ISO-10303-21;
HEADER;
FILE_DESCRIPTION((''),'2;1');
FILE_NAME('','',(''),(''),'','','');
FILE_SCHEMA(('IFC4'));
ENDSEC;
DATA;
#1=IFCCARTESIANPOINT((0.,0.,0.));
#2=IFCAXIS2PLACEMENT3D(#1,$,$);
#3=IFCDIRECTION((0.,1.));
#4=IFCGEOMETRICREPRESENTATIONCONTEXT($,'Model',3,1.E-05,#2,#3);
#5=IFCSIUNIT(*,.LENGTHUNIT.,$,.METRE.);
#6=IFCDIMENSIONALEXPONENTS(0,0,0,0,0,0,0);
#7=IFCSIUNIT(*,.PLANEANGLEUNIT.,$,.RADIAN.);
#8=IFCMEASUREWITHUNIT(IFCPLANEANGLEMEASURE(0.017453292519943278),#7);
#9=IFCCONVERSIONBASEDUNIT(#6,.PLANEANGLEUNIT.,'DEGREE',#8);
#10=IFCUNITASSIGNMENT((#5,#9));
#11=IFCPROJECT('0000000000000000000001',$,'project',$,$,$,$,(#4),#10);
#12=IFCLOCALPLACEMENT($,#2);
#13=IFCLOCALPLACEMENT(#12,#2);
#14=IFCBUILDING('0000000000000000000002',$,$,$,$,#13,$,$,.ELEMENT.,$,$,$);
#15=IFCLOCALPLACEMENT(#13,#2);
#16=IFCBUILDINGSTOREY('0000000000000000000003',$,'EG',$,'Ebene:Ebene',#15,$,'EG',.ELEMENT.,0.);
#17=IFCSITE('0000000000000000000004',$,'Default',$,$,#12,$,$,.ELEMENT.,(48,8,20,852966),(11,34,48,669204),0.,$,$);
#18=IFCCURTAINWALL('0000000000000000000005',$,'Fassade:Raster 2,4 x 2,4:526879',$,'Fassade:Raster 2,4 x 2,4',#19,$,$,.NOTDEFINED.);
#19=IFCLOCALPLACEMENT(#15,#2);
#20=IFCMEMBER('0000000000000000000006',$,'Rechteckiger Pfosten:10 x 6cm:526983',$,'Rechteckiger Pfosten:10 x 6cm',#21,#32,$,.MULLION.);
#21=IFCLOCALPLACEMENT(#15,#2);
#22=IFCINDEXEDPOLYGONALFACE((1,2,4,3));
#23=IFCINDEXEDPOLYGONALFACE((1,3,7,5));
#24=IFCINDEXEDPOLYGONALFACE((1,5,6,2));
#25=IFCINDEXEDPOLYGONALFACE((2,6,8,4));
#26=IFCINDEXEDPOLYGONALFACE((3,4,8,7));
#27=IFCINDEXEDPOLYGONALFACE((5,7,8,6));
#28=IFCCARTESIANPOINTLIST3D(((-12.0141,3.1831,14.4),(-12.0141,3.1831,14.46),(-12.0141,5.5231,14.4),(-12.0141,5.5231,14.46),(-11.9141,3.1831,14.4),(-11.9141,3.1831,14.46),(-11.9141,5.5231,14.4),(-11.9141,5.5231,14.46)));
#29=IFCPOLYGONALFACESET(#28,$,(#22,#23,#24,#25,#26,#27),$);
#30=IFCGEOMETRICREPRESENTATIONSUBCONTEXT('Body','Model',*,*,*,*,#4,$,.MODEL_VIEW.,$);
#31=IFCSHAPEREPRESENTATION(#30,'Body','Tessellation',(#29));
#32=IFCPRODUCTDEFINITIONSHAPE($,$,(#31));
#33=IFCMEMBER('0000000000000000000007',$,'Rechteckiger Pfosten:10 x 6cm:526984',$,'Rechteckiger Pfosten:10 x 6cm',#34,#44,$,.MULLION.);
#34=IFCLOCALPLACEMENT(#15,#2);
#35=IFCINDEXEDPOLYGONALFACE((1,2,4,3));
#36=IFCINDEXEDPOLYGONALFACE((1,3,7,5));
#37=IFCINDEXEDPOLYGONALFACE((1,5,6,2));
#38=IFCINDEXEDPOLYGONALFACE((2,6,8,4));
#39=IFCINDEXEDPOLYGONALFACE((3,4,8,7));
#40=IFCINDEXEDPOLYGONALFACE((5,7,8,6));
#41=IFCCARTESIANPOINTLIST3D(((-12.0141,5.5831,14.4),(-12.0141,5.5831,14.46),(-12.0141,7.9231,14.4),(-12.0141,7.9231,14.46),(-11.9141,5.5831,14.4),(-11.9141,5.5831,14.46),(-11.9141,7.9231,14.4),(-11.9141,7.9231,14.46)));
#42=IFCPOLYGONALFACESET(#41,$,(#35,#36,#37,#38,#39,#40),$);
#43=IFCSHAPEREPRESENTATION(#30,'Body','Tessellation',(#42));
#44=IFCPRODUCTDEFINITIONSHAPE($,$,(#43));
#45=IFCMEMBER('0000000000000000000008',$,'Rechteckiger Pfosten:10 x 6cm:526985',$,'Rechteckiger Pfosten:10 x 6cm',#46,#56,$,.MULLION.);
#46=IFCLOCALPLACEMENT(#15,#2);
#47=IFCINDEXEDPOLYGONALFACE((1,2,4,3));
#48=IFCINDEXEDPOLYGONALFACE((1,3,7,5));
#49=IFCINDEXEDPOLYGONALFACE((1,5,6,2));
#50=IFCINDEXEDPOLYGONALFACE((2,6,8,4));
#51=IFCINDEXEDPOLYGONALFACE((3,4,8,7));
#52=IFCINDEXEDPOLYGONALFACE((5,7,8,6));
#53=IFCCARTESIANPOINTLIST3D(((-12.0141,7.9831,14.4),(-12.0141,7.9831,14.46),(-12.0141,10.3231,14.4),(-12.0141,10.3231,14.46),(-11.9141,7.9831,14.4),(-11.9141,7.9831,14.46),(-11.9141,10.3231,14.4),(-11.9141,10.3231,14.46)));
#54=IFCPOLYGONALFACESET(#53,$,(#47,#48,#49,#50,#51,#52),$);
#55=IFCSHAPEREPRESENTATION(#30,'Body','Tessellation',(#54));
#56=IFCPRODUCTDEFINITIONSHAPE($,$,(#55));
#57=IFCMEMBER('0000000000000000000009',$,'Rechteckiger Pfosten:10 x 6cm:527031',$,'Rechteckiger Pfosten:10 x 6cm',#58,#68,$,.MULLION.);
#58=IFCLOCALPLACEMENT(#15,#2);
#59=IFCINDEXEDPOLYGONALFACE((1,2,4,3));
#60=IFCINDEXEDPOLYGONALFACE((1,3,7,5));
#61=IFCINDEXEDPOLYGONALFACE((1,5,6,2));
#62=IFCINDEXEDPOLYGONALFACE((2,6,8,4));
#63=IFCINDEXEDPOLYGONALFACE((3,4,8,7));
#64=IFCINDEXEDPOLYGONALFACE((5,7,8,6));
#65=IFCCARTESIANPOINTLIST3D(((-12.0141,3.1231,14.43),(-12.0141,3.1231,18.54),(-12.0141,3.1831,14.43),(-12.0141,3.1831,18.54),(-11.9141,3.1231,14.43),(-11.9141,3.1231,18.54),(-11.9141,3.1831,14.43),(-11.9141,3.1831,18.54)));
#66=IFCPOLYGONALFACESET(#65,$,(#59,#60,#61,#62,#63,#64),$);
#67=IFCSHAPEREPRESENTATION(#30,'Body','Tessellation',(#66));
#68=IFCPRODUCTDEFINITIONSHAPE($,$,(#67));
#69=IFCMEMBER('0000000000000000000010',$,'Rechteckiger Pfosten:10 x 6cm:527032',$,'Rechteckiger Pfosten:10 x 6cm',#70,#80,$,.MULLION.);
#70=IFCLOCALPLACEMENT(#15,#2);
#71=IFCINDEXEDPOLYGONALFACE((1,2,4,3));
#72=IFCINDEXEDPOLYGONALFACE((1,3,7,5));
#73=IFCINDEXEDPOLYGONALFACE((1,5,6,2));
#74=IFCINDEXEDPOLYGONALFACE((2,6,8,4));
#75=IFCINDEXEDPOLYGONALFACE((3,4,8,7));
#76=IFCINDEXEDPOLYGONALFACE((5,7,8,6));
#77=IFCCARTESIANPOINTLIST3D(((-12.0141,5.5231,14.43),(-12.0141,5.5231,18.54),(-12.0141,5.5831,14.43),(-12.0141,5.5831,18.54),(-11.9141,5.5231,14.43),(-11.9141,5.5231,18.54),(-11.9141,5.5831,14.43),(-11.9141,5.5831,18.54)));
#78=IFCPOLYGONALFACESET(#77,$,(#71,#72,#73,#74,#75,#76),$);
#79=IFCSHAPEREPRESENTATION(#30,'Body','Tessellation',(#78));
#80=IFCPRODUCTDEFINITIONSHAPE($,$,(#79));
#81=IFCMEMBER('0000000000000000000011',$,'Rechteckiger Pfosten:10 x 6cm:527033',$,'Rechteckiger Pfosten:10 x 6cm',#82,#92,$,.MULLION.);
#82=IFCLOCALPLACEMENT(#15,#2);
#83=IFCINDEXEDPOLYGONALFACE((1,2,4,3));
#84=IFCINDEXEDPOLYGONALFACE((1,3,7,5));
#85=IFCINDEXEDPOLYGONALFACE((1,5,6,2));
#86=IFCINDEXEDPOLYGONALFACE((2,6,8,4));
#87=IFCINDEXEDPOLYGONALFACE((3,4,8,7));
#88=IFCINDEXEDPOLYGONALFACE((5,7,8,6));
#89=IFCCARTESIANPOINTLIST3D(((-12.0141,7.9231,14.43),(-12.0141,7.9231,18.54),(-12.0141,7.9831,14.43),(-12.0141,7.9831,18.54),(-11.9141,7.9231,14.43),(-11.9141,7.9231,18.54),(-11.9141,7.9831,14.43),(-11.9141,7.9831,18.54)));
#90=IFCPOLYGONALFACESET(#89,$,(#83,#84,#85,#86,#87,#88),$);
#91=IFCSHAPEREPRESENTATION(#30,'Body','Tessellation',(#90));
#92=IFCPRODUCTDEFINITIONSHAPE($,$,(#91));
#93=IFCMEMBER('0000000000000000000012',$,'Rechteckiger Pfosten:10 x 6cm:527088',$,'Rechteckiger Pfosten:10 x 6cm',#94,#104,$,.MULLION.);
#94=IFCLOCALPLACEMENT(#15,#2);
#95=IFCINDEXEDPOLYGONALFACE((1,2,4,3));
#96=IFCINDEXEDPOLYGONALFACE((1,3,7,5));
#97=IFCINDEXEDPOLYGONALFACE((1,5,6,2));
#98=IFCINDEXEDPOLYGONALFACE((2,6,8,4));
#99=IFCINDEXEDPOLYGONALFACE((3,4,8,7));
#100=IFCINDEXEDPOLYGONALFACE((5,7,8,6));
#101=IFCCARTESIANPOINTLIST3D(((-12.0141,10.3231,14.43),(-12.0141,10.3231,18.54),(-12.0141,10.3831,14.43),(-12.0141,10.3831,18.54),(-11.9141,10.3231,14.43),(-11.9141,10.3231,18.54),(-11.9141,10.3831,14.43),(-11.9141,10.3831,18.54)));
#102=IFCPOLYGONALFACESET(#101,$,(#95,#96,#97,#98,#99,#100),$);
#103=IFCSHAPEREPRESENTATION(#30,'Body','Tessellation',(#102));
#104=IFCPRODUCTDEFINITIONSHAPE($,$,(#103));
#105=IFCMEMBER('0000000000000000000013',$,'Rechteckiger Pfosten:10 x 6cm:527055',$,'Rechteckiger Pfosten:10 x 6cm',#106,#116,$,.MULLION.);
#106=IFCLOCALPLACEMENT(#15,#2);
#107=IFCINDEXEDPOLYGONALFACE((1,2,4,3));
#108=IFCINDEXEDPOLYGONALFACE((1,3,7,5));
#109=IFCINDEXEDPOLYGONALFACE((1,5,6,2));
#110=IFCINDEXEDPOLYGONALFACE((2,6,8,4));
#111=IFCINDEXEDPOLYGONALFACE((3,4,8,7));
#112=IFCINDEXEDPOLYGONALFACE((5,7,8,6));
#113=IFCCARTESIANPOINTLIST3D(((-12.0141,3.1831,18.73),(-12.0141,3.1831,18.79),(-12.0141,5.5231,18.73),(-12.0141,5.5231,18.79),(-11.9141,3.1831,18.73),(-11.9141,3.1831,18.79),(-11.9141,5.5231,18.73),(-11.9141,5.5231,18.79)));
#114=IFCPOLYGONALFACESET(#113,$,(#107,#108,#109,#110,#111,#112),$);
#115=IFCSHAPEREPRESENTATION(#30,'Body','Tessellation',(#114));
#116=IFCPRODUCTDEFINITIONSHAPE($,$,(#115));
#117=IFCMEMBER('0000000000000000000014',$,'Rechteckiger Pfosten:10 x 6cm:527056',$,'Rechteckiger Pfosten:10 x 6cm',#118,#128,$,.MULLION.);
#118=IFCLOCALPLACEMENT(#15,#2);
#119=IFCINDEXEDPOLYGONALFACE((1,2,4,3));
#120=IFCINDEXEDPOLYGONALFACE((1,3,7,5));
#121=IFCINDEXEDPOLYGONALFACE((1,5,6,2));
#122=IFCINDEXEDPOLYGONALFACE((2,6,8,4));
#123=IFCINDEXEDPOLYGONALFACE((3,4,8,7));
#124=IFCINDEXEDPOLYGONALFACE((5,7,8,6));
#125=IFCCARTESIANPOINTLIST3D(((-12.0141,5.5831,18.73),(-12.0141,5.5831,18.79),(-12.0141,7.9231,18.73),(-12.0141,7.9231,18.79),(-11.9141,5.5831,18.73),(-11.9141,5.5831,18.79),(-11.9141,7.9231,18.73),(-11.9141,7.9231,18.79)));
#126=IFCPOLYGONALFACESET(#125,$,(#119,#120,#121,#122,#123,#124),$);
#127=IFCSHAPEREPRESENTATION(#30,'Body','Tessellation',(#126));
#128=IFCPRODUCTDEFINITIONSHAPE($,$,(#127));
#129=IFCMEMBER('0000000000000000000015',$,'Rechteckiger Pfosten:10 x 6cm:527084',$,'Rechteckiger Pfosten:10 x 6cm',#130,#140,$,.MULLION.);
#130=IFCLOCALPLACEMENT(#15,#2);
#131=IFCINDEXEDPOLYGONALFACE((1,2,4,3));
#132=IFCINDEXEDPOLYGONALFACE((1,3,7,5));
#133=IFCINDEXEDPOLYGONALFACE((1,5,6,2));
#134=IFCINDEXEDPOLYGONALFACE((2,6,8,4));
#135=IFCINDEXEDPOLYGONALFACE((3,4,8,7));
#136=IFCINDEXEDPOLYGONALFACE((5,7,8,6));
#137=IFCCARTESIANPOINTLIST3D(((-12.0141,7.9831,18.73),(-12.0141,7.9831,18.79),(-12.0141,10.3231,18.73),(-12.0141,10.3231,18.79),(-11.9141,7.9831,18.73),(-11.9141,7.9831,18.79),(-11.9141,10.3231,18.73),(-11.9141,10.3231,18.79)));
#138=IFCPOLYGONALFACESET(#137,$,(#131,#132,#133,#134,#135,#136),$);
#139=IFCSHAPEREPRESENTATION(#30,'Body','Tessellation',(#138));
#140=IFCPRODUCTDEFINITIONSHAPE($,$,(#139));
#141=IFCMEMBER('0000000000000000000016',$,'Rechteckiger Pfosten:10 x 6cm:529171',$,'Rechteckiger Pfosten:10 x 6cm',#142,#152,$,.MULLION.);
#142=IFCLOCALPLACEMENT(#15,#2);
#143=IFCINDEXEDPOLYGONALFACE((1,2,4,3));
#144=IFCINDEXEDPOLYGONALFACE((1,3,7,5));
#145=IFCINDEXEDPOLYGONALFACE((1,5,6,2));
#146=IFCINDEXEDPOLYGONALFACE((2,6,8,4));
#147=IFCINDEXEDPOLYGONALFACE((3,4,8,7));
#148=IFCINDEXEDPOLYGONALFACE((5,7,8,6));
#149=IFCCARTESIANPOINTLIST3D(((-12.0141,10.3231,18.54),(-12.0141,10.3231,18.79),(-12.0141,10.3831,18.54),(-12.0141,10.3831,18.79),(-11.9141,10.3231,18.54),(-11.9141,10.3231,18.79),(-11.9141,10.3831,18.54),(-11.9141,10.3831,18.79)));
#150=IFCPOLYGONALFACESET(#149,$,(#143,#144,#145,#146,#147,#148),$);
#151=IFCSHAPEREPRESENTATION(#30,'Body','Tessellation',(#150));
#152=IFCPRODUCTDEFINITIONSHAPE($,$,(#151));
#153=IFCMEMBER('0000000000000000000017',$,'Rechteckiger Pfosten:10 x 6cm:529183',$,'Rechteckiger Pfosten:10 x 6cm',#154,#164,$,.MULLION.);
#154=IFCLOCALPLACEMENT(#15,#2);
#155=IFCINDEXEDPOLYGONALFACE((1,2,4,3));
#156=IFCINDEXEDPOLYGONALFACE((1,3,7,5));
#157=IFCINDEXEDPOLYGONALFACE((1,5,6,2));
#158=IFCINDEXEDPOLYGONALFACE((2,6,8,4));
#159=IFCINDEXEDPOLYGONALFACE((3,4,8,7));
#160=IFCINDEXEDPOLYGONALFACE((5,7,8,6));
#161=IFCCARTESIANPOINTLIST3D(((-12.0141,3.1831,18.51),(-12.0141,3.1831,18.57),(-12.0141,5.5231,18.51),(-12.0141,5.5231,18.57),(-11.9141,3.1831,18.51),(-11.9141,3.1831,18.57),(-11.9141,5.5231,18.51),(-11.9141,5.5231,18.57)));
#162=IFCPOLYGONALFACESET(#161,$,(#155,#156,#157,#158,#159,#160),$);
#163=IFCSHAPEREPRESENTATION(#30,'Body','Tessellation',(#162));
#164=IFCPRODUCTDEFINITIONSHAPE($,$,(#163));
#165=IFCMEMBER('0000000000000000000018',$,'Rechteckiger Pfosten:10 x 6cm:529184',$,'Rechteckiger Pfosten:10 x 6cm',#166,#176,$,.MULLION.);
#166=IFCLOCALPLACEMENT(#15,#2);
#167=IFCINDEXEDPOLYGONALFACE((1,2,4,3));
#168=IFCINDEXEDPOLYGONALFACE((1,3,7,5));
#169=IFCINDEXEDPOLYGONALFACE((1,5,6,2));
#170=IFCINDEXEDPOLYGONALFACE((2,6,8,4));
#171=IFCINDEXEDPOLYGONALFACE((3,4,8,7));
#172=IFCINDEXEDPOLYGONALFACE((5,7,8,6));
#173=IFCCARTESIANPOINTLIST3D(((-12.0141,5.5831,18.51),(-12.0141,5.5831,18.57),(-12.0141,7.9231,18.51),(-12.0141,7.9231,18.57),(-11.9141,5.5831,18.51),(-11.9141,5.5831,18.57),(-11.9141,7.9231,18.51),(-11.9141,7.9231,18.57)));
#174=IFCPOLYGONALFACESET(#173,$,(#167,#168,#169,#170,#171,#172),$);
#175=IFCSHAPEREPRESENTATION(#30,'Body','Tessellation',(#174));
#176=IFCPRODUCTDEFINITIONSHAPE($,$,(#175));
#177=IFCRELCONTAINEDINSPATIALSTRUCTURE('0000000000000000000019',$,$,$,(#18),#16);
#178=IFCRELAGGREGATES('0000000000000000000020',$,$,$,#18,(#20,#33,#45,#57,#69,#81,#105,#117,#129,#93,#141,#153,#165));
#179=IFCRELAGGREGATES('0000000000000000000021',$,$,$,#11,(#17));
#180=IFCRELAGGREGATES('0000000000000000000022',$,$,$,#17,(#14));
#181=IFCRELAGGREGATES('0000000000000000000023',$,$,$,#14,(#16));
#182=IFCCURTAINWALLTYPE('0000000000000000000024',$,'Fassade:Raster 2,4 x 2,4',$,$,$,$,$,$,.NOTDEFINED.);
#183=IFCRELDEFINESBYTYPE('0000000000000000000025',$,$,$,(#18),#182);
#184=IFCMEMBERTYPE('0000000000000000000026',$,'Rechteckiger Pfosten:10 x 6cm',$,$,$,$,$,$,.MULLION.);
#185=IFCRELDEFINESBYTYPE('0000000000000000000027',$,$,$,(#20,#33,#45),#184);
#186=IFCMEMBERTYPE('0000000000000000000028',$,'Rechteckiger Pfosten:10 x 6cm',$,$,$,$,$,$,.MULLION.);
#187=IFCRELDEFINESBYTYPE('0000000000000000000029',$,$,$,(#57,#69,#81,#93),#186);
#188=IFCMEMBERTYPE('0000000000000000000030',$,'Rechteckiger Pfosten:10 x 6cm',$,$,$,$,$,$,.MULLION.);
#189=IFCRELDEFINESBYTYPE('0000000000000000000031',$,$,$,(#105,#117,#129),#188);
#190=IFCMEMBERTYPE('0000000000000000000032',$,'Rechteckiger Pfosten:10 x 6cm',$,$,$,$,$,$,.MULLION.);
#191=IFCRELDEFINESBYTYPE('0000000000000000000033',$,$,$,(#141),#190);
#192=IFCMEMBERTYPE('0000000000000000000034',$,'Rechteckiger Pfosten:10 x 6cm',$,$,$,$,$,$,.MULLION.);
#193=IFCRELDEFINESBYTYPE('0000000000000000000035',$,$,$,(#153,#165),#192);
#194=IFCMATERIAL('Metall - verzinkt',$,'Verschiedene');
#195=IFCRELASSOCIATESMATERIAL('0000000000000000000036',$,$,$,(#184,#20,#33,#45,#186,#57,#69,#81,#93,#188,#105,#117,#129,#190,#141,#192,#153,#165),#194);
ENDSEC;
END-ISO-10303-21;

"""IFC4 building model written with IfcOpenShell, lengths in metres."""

from ifc_helpers import new_model, entity, si_unit, converted_unit, direction, frame, origin, place, context, subcontext, project, spatial, indexed_curve, outline, extrude, source, transform, mapped, material, type_object, type_shapes, element, aggregate, save


model = new_model("IFC4")

# Units and contexts
model_context = context("Model", 3, precision=1e-05, world=origin(), true_north=direction((0.0, 1.0)))
body_context = subcontext(model_context, "Body", "Model", "MODEL_VIEW")
ifc_project = project(units=[si_unit("LENGTHUNIT", "METRE"), converted_unit("PLANEANGLEUNIT", "DEGREE", entity("IfcPlaneAngleMeasure", 0.017453292519943278), si_unit("PLANEANGLEUNIT", "RADIAN"), dimensions=[0, 0, 0, 0, 0, 0, 0])], contexts=[model_context])

# Site, building, storey
site_placement = place(None, origin())
site = spatial("IfcSite", under=ifc_project, at=site_placement, Name="Default", CompositionType="ELEMENT", RefLatitude=(48, 8, 20, 852966), RefLongitude=(11, 34, 48, 669204), RefElevation=0.0)
building_placement = place(site_placement, origin())
building = spatial("IfcBuilding", under=site, at=building_placement, CompositionType="ELEMENT")
storey_placement = place(building_placement, origin())
storey = spatial("IfcBuildingStorey", under=building, at=storey_placement, Name="EG", ObjectType="Ebene:Ebene", LongName="EG", CompositionType="ELEMENT", Elevation=0.0)

# Curtain wall, members
curtain_wall_type = type_object("IfcCurtainWallType", Name="Fassade:Raster 2,4 x 2,4", PredefinedType="NOTDEFINED")
curtain_wall_placement = place(storey_placement, origin())
curtain_wall = element("IfcCurtainWall", 1, at=curtain_wall_placement, inside=storey, type_object=curtain_wall_type, Name="Fassade:Raster 2,4 x 2,4:526879", ObjectType="Fassade:Raster 2,4 x 2,4", PredefinedType="NOTDEFINED")
ifc_material_1 = material(Name="Metall - verzinkt", Category="Verschiedene")
member_type_1 = type_object("IfcMemberType", Name="Rechteckiger Pfosten:10 x 6cm", PredefinedType="MULLION", material=ifc_material_1)
shared_shape_1 = source(origin(), body_context, "Body", "SweptSolid", [
    extrude(outline(indexed_curve([(-0.03, -0.05), (0.03, -0.05), (0.03, 0.05), (-0.03, 0.05), (-0.03, -0.05)], self_intersect=False)), frame((0.0, 0.0, -2.34), z_axis=(0.0, 0.0, 1.0), x_axis=(-1.0, 0.0, 0.0)), (0.0, 0.0, 1.0), 2.34),
])
type_shapes(member_type_1, [shared_shape_1])
member_1_placement = place(curtain_wall_placement, frame((-11.9641, 5.5231, 14.43), z_axis=(0.0, 1.0, 0.0), x_axis=(0.0, 0.0, 1.0)))
member_1 = element("IfcMember", 2, at=member_1_placement, type_object=member_type_1, material=ifc_material_1, Name="Rechteckiger Pfosten:10 x 6cm:526983", ObjectType="Rechteckiger Pfosten:10 x 6cm", PredefinedType="MULLION", context=body_context, shape_type="MappedRepresentation", body=[
    mapped(shared_shape_1, transform((0.0, 0.0, 0.0), scale=1.0)),
])
member_2_placement = place(curtain_wall_placement, frame((-11.9641, 7.9231, 14.43), z_axis=(0.0, 1.0, 0.0), x_axis=(0.0, 0.0, 1.0)))
member_2 = element("IfcMember", 3, at=member_2_placement, type_object=member_type_1, material=ifc_material_1, Name="Rechteckiger Pfosten:10 x 6cm:526984", ObjectType="Rechteckiger Pfosten:10 x 6cm", PredefinedType="MULLION", context=body_context, shape_type="MappedRepresentation", body=[
    mapped(shared_shape_1, transform((0.0, 0.0, 0.0), scale=1.0)),
])
member_3_placement = place(curtain_wall_placement, frame((-11.9641, 10.3231, 14.43), z_axis=(0.0, 1.0, 0.0), x_axis=(0.0, 0.0, 1.0)))
member_3 = element("IfcMember", 4, at=member_3_placement, type_object=member_type_1, material=ifc_material_1, Name="Rechteckiger Pfosten:10 x 6cm:526985", ObjectType="Rechteckiger Pfosten:10 x 6cm", PredefinedType="MULLION", context=body_context, shape_type="MappedRepresentation", body=[
    mapped(shared_shape_1, transform((0.0, 0.0, 0.0), scale=1.0)),
])
member_type_2 = type_object("IfcMemberType", Name="Rechteckiger Pfosten:10 x 6cm", PredefinedType="MULLION", material=ifc_material_1)
shared_shape_2 = source(origin(), body_context, "Body", "SweptSolid", [
    extrude(outline(indexed_curve([(-0.03, -0.05), (0.03, -0.05), (0.03, 0.05), (-0.03, 0.05), (-0.03, -0.05)], self_intersect=False)), frame((0.0, 0.0, -4.11), z_axis=(0.0, 0.0, 1.0), x_axis=(-1.0, 0.0, 0.0)), (0.0, 0.0, 1.0), 4.11),
])
type_shapes(member_type_2, [shared_shape_2])
member_4_placement = place(curtain_wall_placement, frame((-11.9641, 3.1531, 14.43), z_axis=(0.0, 0.0, -1.0), x_axis=(0.0, 1.0, 0.0)))
member_4 = element("IfcMember", 5, at=member_4_placement, type_object=member_type_2, material=ifc_material_1, Name="Rechteckiger Pfosten:10 x 6cm:527031", ObjectType="Rechteckiger Pfosten:10 x 6cm", PredefinedType="MULLION", context=body_context, shape_type="MappedRepresentation", body=[
    mapped(shared_shape_2, transform((0.0, 0.0, 0.0), scale=1.0)),
])
member_5_placement = place(curtain_wall_placement, frame((-11.9641, 5.5531, 14.43), z_axis=(0.0, 0.0, -1.0), x_axis=(0.0, 1.0, 0.0)))
member_5 = element("IfcMember", 6, at=member_5_placement, type_object=member_type_2, material=ifc_material_1, Name="Rechteckiger Pfosten:10 x 6cm:527032", ObjectType="Rechteckiger Pfosten:10 x 6cm", PredefinedType="MULLION", context=body_context, shape_type="MappedRepresentation", body=[
    mapped(shared_shape_2, transform((0.0, 0.0, 0.0), scale=1.0)),
])
member_6_placement = place(curtain_wall_placement, frame((-11.9641, 7.9531, 14.43), z_axis=(0.0, 0.0, -1.0), x_axis=(0.0, 1.0, 0.0)))
member_6 = element("IfcMember", 7, at=member_6_placement, type_object=member_type_2, material=ifc_material_1, Name="Rechteckiger Pfosten:10 x 6cm:527033", ObjectType="Rechteckiger Pfosten:10 x 6cm", PredefinedType="MULLION", context=body_context, shape_type="MappedRepresentation", body=[
    mapped(shared_shape_2, transform((0.0, 0.0, 0.0), scale=1.0)),
])
member_7_placement = place(curtain_wall_placement, frame((-11.9641, 10.3531, 14.43), z_axis=(0.0, 0.0, -1.0), x_axis=(0.0, 1.0, 0.0)))
member_7 = element("IfcMember", 8, at=member_7_placement, type_object=member_type_2, material=ifc_material_1, Name="Rechteckiger Pfosten:10 x 6cm:527088", ObjectType="Rechteckiger Pfosten:10 x 6cm", PredefinedType="MULLION", context=body_context, shape_type="MappedRepresentation", body=[
    mapped(shared_shape_2, transform((0.0, 0.0, 0.0), scale=1.0)),
])
member_type_3 = type_object("IfcMemberType", Name="Rechteckiger Pfosten:10 x 6cm", PredefinedType="MULLION", material=ifc_material_1)
shared_shape_3 = source(origin(), body_context, "Body", "SweptSolid", [
    extrude(outline(indexed_curve([(-0.03, -0.05), (0.03, -0.05), (0.03, 0.05), (-0.03, 0.05), (-0.03, -0.05)], self_intersect=False)), frame((-0.03, 0.0, -2.34), z_axis=(0.0, 0.0, 1.0), x_axis=(-1.0, 0.0, 0.0)), (0.0, 0.0, 1.0), 2.34),
])
type_shapes(member_type_3, [shared_shape_3])
member_8_placement = place(curtain_wall_placement, frame((-11.9641, 5.5231, 18.79), z_axis=(0.0, 1.0, 0.0), x_axis=(0.0, 0.0, 1.0)))
member_8 = element("IfcMember", 9, at=member_8_placement, type_object=member_type_3, material=ifc_material_1, Name="Rechteckiger Pfosten:10 x 6cm:527055", ObjectType="Rechteckiger Pfosten:10 x 6cm", PredefinedType="MULLION", context=body_context, shape_type="MappedRepresentation", body=[
    mapped(shared_shape_3, transform((0.0, 0.0, 0.0), scale=1.0)),
])
member_9_placement = place(curtain_wall_placement, frame((-11.9641, 7.9231, 18.79), z_axis=(0.0, 1.0, 0.0), x_axis=(0.0, 0.0, 1.0)))
member_9 = element("IfcMember", 10, at=member_9_placement, type_object=member_type_3, material=ifc_material_1, Name="Rechteckiger Pfosten:10 x 6cm:527056", ObjectType="Rechteckiger Pfosten:10 x 6cm", PredefinedType="MULLION", context=body_context, shape_type="MappedRepresentation", body=[
    mapped(shared_shape_3, transform((0.0, 0.0, 0.0), scale=1.0)),
])
member_10_placement = place(curtain_wall_placement, frame((-11.9641, 10.3231, 18.79), z_axis=(0.0, 1.0, 0.0), x_axis=(0.0, 0.0, 1.0)))
member_10 = element("IfcMember", 11, at=member_10_placement, type_object=member_type_3, material=ifc_material_1, Name="Rechteckiger Pfosten:10 x 6cm:527084", ObjectType="Rechteckiger Pfosten:10 x 6cm", PredefinedType="MULLION", context=body_context, shape_type="MappedRepresentation", body=[
    mapped(shared_shape_3, transform((0.0, 0.0, 0.0), scale=1.0)),
])
member_type_4 = type_object("IfcMemberType", Name="Rechteckiger Pfosten:10 x 6cm", PredefinedType="MULLION", material=ifc_material_1)
shared_shape_4 = source(origin(), body_context, "Body", "SweptSolid", [
    extrude(outline(indexed_curve([(-0.03, -0.05), (0.03, -0.05), (0.03, 0.05), (-0.03, 0.05), (-0.03, -0.05)], self_intersect=False)), frame((-0.03, 0.0, -0.25), z_axis=(0.0, 0.0, 1.0), x_axis=(-1.0, 0.0, 0.0)), (0.0, 0.0, 1.0), 0.25),
])
type_shapes(member_type_4, [shared_shape_4])
member_11_placement = place(curtain_wall_placement, frame((-11.9641, 10.3831, 18.54), z_axis=(0.0, 0.0, -1.0), x_axis=(0.0, 1.0, 0.0)))
member_11 = element("IfcMember", 12, at=member_11_placement, type_object=member_type_4, material=ifc_material_1, Name="Rechteckiger Pfosten:10 x 6cm:529171", ObjectType="Rechteckiger Pfosten:10 x 6cm", PredefinedType="MULLION", context=body_context, shape_type="MappedRepresentation", body=[
    mapped(shared_shape_4, transform((0.0, 0.0, 0.0), scale=1.0)),
])
member_type_5 = type_object("IfcMemberType", Name="Rechteckiger Pfosten:10 x 6cm", PredefinedType="MULLION", material=ifc_material_1)
shared_shape_5 = source(origin(), body_context, "Body", "SweptSolid", [
    extrude(outline(indexed_curve([(-0.03, -0.05), (0.03, -0.05), (0.03, 0.05), (-0.03, 0.05), (-0.03, -0.05)], self_intersect=False)), frame((0.0, 0.0, -2.34), z_axis=(0.0, 0.0, 1.0), x_axis=(-1.0, 0.0, 0.0)), (0.0, 0.0, 1.0), 2.34),
])
type_shapes(member_type_5, [shared_shape_5])
member_12_placement = place(curtain_wall_placement, frame((-11.9641, 5.5231, 18.54), z_axis=(0.0, 1.0, 0.0), x_axis=(0.0, 0.0, 1.0)))
member_12 = element("IfcMember", 13, at=member_12_placement, type_object=member_type_5, material=ifc_material_1, Name="Rechteckiger Pfosten:10 x 6cm:529183", ObjectType="Rechteckiger Pfosten:10 x 6cm", PredefinedType="MULLION", context=body_context, shape_type="MappedRepresentation", body=[
    mapped(shared_shape_5, transform((0.0, 0.0, 0.0), scale=1.0)),
])
member_13_placement = place(curtain_wall_placement, frame((-11.9641, 7.9231, 18.54), z_axis=(0.0, 1.0, 0.0), x_axis=(0.0, 0.0, 1.0)))
member_13 = element("IfcMember", 14, at=member_13_placement, type_object=member_type_5, material=ifc_material_1, Name="Rechteckiger Pfosten:10 x 6cm:529184", ObjectType="Rechteckiger Pfosten:10 x 6cm", PredefinedType="MULLION", context=body_context, shape_type="MappedRepresentation", body=[
    mapped(shared_shape_5, transform((0.0, 0.0, 0.0), scale=1.0)),
])
aggregate(curtain_wall, [member_1, member_2, member_3, member_4, member_5, member_6, member_8, member_9, member_10, member_7, member_11, member_12, member_13])

save(model, "model.ifc")
